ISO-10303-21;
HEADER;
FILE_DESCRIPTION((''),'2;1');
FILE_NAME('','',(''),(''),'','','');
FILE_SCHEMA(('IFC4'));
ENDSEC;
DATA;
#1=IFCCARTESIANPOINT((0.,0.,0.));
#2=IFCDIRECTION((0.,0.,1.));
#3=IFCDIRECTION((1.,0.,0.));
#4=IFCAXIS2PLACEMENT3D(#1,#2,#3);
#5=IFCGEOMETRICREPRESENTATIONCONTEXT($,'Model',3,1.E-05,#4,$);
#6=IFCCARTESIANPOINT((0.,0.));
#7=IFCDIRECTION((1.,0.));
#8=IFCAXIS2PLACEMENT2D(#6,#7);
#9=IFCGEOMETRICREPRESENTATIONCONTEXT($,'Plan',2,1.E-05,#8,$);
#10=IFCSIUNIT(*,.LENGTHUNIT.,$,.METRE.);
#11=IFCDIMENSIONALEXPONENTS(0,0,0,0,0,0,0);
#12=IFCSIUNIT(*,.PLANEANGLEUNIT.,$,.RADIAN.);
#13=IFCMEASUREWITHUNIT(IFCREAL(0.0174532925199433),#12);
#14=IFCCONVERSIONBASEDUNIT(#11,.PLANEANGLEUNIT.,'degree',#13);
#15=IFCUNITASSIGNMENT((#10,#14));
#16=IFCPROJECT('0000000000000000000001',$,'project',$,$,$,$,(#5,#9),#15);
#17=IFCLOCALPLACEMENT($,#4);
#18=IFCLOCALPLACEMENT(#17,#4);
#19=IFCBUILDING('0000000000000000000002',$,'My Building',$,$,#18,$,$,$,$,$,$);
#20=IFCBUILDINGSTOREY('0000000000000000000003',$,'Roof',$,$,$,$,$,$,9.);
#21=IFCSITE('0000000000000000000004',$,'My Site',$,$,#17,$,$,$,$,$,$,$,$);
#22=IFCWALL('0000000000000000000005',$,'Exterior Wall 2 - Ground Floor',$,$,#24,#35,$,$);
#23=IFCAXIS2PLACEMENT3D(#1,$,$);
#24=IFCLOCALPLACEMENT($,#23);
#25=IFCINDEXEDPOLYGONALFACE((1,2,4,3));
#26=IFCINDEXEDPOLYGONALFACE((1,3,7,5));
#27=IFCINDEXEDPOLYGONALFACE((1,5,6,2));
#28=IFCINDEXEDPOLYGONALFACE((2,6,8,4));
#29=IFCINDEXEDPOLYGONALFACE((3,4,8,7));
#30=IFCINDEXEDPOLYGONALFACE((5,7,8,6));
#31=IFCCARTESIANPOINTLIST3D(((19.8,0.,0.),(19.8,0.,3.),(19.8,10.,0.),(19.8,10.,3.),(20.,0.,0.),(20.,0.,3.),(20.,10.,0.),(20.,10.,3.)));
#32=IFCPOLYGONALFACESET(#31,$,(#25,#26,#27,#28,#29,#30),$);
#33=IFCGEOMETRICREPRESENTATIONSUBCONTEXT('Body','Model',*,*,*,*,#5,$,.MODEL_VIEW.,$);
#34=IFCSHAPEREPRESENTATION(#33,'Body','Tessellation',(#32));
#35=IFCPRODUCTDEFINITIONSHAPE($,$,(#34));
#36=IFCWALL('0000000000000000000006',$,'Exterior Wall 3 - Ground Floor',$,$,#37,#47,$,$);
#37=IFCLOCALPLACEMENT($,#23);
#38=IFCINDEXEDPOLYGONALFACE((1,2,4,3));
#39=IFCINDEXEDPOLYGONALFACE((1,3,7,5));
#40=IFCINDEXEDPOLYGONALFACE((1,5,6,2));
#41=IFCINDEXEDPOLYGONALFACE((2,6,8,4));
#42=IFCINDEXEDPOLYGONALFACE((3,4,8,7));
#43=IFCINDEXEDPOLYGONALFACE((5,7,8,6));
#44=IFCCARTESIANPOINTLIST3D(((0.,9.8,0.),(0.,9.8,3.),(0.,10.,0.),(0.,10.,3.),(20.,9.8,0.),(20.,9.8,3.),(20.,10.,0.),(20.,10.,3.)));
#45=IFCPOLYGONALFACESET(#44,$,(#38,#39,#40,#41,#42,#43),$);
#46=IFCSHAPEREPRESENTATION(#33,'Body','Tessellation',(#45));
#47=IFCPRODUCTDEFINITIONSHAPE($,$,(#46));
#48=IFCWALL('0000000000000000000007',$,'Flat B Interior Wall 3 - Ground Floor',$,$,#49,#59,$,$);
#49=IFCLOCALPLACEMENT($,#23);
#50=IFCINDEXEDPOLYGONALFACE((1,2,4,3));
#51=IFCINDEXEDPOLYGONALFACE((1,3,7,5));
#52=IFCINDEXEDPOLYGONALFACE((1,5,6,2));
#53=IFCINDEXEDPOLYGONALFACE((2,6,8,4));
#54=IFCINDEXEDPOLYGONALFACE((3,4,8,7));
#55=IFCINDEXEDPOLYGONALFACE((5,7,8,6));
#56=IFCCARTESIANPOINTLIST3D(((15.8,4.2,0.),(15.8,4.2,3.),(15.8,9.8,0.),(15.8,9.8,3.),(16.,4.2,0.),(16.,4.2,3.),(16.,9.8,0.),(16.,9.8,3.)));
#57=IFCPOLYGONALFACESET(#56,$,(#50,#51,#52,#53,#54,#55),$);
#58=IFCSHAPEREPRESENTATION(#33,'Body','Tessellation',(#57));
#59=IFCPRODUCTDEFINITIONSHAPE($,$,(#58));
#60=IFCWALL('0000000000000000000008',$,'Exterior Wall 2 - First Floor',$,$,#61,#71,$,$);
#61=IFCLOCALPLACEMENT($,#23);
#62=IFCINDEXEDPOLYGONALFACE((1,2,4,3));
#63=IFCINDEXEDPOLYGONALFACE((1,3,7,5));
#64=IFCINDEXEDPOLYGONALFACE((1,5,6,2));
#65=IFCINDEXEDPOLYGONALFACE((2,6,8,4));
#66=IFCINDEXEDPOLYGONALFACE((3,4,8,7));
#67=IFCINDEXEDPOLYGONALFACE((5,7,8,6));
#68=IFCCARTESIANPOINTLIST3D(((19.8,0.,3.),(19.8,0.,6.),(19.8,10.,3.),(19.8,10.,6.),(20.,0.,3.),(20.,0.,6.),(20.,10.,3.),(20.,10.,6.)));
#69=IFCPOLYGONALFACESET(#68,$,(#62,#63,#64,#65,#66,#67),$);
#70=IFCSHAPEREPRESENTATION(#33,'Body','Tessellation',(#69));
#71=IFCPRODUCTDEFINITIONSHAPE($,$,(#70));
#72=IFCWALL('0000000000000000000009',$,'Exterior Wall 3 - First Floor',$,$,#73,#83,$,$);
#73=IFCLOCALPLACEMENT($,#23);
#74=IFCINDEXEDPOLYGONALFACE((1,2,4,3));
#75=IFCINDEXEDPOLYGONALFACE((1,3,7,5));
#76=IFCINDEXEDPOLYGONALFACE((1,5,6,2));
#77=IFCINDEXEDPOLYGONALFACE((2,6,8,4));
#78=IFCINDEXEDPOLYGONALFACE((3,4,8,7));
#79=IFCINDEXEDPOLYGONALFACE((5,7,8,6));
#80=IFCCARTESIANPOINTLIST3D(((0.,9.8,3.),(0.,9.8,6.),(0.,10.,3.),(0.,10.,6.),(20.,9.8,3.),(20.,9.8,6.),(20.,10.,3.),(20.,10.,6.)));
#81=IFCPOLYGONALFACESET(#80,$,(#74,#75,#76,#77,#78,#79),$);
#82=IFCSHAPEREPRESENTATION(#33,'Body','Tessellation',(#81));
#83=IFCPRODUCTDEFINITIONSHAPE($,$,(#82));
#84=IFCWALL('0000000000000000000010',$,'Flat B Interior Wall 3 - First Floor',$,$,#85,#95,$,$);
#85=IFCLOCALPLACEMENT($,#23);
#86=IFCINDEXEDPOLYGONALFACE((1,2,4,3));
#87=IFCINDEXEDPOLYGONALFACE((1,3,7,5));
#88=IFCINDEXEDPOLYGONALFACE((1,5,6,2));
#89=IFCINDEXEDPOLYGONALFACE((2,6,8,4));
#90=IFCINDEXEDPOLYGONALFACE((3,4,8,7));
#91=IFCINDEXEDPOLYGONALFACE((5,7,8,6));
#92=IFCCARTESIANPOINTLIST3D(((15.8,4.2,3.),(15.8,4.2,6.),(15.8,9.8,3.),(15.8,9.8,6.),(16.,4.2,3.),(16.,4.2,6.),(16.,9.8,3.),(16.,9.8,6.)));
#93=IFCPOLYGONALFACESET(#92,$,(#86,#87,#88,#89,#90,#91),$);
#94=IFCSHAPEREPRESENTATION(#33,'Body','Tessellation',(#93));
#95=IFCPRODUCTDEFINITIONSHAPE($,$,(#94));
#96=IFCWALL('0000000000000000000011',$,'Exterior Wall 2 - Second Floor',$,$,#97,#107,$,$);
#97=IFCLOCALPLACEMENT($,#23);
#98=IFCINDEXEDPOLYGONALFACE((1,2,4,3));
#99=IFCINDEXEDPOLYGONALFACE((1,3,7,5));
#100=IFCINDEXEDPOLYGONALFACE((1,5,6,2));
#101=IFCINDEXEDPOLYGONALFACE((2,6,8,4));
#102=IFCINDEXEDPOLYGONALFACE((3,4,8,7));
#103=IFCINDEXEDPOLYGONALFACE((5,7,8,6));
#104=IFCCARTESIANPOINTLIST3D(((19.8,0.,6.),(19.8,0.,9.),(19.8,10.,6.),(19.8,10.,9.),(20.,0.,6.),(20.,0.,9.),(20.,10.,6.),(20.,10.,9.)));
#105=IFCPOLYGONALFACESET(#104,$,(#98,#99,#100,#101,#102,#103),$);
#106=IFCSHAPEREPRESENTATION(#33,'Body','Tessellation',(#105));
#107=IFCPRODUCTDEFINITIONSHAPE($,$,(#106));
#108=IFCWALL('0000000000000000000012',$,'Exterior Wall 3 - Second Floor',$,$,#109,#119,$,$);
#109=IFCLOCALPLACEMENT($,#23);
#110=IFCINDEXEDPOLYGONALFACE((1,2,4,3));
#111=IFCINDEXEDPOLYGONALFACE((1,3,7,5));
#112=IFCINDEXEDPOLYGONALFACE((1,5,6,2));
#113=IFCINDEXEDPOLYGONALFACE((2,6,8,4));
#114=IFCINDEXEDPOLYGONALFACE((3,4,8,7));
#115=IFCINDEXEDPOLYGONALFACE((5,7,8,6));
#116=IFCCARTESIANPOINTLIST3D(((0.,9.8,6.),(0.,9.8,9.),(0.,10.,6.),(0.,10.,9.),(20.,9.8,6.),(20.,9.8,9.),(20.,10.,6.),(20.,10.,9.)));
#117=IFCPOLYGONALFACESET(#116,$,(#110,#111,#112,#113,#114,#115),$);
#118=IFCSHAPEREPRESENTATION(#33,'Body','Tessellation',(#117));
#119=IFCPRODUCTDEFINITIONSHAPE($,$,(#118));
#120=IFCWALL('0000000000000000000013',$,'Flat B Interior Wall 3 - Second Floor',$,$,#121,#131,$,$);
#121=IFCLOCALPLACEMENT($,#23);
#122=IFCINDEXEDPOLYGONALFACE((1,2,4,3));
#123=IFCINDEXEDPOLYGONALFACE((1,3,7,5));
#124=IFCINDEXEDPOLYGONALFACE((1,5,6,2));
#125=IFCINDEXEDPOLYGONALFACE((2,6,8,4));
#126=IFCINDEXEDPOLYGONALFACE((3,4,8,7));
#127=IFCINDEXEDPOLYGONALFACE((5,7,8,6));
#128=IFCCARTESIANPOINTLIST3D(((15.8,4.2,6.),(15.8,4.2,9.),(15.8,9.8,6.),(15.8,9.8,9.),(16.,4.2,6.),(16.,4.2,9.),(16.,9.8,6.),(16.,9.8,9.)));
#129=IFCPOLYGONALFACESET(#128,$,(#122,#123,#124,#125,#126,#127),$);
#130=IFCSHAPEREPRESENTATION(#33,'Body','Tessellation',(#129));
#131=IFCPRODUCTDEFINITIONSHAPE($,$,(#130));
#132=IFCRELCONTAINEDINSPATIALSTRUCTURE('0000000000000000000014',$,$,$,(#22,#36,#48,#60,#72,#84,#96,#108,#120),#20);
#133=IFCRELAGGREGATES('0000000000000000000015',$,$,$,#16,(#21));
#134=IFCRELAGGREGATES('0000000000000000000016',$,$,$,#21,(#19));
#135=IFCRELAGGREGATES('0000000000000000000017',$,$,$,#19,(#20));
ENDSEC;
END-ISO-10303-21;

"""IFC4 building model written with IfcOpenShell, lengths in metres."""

from ifc_helpers import new_model, entity, si_unit, converted_unit, frame, origin_with_axes, origin_2d_with_axis, place, context, subcontext, project, spatial, indexed_curve, outline, extrude, element, save


model = new_model("IFC4")

# Units and contexts
model_context = context("Model", 3, precision=1e-05, world=origin_with_axes())
plan_context = context("Plan", 2, precision=1e-05, world=origin_2d_with_axis())
body_context = subcontext(model_context, "Body", "Model", "MODEL_VIEW")
ifc_project = project(units=[si_unit("LENGTHUNIT", "METRE"), converted_unit("PLANEANGLEUNIT", "degree", entity("IfcReal", 0.0174532925199433), si_unit("PLANEANGLEUNIT", "RADIAN"), dimensions=[0, 0, 0, 0, 0, 0, 0])], contexts=[model_context, plan_context])

# Site, building, storey
site_placement = place(None, origin_with_axes())
site = spatial("IfcSite", under=ifc_project, at=site_placement, Name="My Site")
building_placement = place(site_placement, origin_with_axes())
building = spatial("IfcBuilding", under=site, at=building_placement, Name="My Building")
storey = spatial("IfcBuildingStorey", under=building, Name="Roof", Elevation=9.0)

# Walls
wall_1_placement = place(None, frame((20.0, 0.0, 0.0), z_axis=(0.0, 0.0, 1.0), x_axis=(0.0, 1.0, 0.0)))
element("IfcWall", 1, at=wall_1_placement, inside=storey, Name="Exterior Wall 2 - Ground Floor", context=body_context, shape_type="SweptSolid", body=[
    extrude(outline(indexed_curve([(0.0, 0.0), (0.0, 0.2), (10.0, 0.2), (10.0, 0.0), (0.0, 0.0)], self_intersect=False)), origin_with_axes(), (0.0, 0.0, 1.0), 3.0),
])
wall_2_placement = place(None, frame((20.0, 10.0, 0.0), z_axis=(0.0, 0.0, 1.0), x_axis=(-1.0, 0.0, 0.0)))
element("IfcWall", 2, at=wall_2_placement, inside=storey, Name="Exterior Wall 3 - Ground Floor", context=body_context, shape_type="SweptSolid", body=[
    extrude(outline(indexed_curve([(0.0, 0.0), (0.0, 0.2), (20.0, 0.2), (20.0, 0.0), (0.0, 0.0)], self_intersect=False)), origin_with_axes(), (0.0, 0.0, 1.0), 3.0),
])
wall_3_placement = place(None, frame((16.0, 4.2, 0.0), z_axis=(0.0, 0.0, 1.0), x_axis=(0.0, 1.0, 0.0)))
element("IfcWall", 3, at=wall_3_placement, inside=storey, Name="Flat B Interior Wall 3 - Ground Floor", context=body_context, shape_type="SweptSolid", body=[
    extrude(outline(indexed_curve([(0.0, 0.0), (0.0, 0.2), (5.6, 0.2), (5.6, 0.0), (0.0, 0.0)], self_intersect=False)), origin_with_axes(), (0.0, 0.0, 1.0), 3.0),
])
wall_4_placement = place(None, frame((20.0, 0.0, 3.0), z_axis=(0.0, 0.0, 1.0), x_axis=(0.0, 1.0, 0.0)))
element("IfcWall", 4, at=wall_4_placement, inside=storey, Name="Exterior Wall 2 - First Floor", context=body_context, shape_type="SweptSolid", body=[
    extrude(outline(indexed_curve([(0.0, 0.0), (0.0, 0.2), (10.0, 0.2), (10.0, 0.0), (0.0, 0.0)], self_intersect=False)), origin_with_axes(), (0.0, 0.0, 1.0), 3.0),
])
wall_5_placement = place(None, frame((20.0, 10.0, 3.0), z_axis=(0.0, 0.0, 1.0), x_axis=(-1.0, 0.0, 0.0)))
element("IfcWall", 5, at=wall_5_placement, inside=storey, Name="Exterior Wall 3 - First Floor", context=body_context, shape_type="SweptSolid", body=[
    extrude(outline(indexed_curve([(0.0, 0.0), (0.0, 0.2), (20.0, 0.2), (20.0, 0.0), (0.0, 0.0)], self_intersect=False)), origin_with_axes(), (0.0, 0.0, 1.0), 3.0),
])
wall_6_placement = place(None, frame((16.0, 4.2, 3.0), z_axis=(0.0, 0.0, 1.0), x_axis=(0.0, 1.0, 0.0)))
element("IfcWall", 6, at=wall_6_placement, inside=storey, Name="Flat B Interior Wall 3 - First Floor", context=body_context, shape_type="SweptSolid", body=[
    extrude(outline(indexed_curve([(0.0, 0.0), (0.0, 0.2), (5.6, 0.2), (5.6, 0.0), (0.0, 0.0)], self_intersect=False)), origin_with_axes(), (0.0, 0.0, 1.0), 3.0),
])
wall_7_placement = place(None, frame((20.0, 0.0, 6.0), z_axis=(0.0, 0.0, 1.0), x_axis=(0.0, 1.0, 0.0)))
element("IfcWall", 7, at=wall_7_placement, inside=storey, Name="Exterior Wall 2 - Second Floor", context=body_context, shape_type="SweptSolid", body=[
    extrude(outline(indexed_curve([(0.0, 0.0), (0.0, 0.2), (10.0, 0.2), (10.0, 0.0), (0.0, 0.0)], self_intersect=False)), origin_with_axes(), (0.0, 0.0, 1.0), 3.0),
])
wall_8_placement = place(None, frame((20.0, 10.0, 6.0), z_axis=(0.0, 0.0, 1.0), x_axis=(-1.0, 0.0, 0.0)))
element("IfcWall", 8, at=wall_8_placement, inside=storey, Name="Exterior Wall 3 - Second Floor", context=body_context, shape_type="SweptSolid", body=[
    extrude(outline(indexed_curve([(0.0, 0.0), (0.0, 0.2), (20.0, 0.2), (20.0, 0.0), (0.0, 0.0)], self_intersect=False)), origin_with_axes(), (0.0, 0.0, 1.0), 3.0),
])
wall_9_placement = place(None, frame((16.0, 4.2, 6.0), z_axis=(0.0, 0.0, 1.0), x_axis=(0.0, 1.0, 0.0)))
element("IfcWall", 9, at=wall_9_placement, inside=storey, Name="Flat B Interior Wall 3 - Second Floor", context=body_context, shape_type="SweptSolid", body=[
    extrude(outline(indexed_curve([(0.0, 0.0), (0.0, 0.2), (5.6, 0.2), (5.6, 0.0), (0.0, 0.0)], self_intersect=False)), origin_with_axes(), (0.0, 0.0, 1.0), 3.0),
])

save(model, "model.ifc")
